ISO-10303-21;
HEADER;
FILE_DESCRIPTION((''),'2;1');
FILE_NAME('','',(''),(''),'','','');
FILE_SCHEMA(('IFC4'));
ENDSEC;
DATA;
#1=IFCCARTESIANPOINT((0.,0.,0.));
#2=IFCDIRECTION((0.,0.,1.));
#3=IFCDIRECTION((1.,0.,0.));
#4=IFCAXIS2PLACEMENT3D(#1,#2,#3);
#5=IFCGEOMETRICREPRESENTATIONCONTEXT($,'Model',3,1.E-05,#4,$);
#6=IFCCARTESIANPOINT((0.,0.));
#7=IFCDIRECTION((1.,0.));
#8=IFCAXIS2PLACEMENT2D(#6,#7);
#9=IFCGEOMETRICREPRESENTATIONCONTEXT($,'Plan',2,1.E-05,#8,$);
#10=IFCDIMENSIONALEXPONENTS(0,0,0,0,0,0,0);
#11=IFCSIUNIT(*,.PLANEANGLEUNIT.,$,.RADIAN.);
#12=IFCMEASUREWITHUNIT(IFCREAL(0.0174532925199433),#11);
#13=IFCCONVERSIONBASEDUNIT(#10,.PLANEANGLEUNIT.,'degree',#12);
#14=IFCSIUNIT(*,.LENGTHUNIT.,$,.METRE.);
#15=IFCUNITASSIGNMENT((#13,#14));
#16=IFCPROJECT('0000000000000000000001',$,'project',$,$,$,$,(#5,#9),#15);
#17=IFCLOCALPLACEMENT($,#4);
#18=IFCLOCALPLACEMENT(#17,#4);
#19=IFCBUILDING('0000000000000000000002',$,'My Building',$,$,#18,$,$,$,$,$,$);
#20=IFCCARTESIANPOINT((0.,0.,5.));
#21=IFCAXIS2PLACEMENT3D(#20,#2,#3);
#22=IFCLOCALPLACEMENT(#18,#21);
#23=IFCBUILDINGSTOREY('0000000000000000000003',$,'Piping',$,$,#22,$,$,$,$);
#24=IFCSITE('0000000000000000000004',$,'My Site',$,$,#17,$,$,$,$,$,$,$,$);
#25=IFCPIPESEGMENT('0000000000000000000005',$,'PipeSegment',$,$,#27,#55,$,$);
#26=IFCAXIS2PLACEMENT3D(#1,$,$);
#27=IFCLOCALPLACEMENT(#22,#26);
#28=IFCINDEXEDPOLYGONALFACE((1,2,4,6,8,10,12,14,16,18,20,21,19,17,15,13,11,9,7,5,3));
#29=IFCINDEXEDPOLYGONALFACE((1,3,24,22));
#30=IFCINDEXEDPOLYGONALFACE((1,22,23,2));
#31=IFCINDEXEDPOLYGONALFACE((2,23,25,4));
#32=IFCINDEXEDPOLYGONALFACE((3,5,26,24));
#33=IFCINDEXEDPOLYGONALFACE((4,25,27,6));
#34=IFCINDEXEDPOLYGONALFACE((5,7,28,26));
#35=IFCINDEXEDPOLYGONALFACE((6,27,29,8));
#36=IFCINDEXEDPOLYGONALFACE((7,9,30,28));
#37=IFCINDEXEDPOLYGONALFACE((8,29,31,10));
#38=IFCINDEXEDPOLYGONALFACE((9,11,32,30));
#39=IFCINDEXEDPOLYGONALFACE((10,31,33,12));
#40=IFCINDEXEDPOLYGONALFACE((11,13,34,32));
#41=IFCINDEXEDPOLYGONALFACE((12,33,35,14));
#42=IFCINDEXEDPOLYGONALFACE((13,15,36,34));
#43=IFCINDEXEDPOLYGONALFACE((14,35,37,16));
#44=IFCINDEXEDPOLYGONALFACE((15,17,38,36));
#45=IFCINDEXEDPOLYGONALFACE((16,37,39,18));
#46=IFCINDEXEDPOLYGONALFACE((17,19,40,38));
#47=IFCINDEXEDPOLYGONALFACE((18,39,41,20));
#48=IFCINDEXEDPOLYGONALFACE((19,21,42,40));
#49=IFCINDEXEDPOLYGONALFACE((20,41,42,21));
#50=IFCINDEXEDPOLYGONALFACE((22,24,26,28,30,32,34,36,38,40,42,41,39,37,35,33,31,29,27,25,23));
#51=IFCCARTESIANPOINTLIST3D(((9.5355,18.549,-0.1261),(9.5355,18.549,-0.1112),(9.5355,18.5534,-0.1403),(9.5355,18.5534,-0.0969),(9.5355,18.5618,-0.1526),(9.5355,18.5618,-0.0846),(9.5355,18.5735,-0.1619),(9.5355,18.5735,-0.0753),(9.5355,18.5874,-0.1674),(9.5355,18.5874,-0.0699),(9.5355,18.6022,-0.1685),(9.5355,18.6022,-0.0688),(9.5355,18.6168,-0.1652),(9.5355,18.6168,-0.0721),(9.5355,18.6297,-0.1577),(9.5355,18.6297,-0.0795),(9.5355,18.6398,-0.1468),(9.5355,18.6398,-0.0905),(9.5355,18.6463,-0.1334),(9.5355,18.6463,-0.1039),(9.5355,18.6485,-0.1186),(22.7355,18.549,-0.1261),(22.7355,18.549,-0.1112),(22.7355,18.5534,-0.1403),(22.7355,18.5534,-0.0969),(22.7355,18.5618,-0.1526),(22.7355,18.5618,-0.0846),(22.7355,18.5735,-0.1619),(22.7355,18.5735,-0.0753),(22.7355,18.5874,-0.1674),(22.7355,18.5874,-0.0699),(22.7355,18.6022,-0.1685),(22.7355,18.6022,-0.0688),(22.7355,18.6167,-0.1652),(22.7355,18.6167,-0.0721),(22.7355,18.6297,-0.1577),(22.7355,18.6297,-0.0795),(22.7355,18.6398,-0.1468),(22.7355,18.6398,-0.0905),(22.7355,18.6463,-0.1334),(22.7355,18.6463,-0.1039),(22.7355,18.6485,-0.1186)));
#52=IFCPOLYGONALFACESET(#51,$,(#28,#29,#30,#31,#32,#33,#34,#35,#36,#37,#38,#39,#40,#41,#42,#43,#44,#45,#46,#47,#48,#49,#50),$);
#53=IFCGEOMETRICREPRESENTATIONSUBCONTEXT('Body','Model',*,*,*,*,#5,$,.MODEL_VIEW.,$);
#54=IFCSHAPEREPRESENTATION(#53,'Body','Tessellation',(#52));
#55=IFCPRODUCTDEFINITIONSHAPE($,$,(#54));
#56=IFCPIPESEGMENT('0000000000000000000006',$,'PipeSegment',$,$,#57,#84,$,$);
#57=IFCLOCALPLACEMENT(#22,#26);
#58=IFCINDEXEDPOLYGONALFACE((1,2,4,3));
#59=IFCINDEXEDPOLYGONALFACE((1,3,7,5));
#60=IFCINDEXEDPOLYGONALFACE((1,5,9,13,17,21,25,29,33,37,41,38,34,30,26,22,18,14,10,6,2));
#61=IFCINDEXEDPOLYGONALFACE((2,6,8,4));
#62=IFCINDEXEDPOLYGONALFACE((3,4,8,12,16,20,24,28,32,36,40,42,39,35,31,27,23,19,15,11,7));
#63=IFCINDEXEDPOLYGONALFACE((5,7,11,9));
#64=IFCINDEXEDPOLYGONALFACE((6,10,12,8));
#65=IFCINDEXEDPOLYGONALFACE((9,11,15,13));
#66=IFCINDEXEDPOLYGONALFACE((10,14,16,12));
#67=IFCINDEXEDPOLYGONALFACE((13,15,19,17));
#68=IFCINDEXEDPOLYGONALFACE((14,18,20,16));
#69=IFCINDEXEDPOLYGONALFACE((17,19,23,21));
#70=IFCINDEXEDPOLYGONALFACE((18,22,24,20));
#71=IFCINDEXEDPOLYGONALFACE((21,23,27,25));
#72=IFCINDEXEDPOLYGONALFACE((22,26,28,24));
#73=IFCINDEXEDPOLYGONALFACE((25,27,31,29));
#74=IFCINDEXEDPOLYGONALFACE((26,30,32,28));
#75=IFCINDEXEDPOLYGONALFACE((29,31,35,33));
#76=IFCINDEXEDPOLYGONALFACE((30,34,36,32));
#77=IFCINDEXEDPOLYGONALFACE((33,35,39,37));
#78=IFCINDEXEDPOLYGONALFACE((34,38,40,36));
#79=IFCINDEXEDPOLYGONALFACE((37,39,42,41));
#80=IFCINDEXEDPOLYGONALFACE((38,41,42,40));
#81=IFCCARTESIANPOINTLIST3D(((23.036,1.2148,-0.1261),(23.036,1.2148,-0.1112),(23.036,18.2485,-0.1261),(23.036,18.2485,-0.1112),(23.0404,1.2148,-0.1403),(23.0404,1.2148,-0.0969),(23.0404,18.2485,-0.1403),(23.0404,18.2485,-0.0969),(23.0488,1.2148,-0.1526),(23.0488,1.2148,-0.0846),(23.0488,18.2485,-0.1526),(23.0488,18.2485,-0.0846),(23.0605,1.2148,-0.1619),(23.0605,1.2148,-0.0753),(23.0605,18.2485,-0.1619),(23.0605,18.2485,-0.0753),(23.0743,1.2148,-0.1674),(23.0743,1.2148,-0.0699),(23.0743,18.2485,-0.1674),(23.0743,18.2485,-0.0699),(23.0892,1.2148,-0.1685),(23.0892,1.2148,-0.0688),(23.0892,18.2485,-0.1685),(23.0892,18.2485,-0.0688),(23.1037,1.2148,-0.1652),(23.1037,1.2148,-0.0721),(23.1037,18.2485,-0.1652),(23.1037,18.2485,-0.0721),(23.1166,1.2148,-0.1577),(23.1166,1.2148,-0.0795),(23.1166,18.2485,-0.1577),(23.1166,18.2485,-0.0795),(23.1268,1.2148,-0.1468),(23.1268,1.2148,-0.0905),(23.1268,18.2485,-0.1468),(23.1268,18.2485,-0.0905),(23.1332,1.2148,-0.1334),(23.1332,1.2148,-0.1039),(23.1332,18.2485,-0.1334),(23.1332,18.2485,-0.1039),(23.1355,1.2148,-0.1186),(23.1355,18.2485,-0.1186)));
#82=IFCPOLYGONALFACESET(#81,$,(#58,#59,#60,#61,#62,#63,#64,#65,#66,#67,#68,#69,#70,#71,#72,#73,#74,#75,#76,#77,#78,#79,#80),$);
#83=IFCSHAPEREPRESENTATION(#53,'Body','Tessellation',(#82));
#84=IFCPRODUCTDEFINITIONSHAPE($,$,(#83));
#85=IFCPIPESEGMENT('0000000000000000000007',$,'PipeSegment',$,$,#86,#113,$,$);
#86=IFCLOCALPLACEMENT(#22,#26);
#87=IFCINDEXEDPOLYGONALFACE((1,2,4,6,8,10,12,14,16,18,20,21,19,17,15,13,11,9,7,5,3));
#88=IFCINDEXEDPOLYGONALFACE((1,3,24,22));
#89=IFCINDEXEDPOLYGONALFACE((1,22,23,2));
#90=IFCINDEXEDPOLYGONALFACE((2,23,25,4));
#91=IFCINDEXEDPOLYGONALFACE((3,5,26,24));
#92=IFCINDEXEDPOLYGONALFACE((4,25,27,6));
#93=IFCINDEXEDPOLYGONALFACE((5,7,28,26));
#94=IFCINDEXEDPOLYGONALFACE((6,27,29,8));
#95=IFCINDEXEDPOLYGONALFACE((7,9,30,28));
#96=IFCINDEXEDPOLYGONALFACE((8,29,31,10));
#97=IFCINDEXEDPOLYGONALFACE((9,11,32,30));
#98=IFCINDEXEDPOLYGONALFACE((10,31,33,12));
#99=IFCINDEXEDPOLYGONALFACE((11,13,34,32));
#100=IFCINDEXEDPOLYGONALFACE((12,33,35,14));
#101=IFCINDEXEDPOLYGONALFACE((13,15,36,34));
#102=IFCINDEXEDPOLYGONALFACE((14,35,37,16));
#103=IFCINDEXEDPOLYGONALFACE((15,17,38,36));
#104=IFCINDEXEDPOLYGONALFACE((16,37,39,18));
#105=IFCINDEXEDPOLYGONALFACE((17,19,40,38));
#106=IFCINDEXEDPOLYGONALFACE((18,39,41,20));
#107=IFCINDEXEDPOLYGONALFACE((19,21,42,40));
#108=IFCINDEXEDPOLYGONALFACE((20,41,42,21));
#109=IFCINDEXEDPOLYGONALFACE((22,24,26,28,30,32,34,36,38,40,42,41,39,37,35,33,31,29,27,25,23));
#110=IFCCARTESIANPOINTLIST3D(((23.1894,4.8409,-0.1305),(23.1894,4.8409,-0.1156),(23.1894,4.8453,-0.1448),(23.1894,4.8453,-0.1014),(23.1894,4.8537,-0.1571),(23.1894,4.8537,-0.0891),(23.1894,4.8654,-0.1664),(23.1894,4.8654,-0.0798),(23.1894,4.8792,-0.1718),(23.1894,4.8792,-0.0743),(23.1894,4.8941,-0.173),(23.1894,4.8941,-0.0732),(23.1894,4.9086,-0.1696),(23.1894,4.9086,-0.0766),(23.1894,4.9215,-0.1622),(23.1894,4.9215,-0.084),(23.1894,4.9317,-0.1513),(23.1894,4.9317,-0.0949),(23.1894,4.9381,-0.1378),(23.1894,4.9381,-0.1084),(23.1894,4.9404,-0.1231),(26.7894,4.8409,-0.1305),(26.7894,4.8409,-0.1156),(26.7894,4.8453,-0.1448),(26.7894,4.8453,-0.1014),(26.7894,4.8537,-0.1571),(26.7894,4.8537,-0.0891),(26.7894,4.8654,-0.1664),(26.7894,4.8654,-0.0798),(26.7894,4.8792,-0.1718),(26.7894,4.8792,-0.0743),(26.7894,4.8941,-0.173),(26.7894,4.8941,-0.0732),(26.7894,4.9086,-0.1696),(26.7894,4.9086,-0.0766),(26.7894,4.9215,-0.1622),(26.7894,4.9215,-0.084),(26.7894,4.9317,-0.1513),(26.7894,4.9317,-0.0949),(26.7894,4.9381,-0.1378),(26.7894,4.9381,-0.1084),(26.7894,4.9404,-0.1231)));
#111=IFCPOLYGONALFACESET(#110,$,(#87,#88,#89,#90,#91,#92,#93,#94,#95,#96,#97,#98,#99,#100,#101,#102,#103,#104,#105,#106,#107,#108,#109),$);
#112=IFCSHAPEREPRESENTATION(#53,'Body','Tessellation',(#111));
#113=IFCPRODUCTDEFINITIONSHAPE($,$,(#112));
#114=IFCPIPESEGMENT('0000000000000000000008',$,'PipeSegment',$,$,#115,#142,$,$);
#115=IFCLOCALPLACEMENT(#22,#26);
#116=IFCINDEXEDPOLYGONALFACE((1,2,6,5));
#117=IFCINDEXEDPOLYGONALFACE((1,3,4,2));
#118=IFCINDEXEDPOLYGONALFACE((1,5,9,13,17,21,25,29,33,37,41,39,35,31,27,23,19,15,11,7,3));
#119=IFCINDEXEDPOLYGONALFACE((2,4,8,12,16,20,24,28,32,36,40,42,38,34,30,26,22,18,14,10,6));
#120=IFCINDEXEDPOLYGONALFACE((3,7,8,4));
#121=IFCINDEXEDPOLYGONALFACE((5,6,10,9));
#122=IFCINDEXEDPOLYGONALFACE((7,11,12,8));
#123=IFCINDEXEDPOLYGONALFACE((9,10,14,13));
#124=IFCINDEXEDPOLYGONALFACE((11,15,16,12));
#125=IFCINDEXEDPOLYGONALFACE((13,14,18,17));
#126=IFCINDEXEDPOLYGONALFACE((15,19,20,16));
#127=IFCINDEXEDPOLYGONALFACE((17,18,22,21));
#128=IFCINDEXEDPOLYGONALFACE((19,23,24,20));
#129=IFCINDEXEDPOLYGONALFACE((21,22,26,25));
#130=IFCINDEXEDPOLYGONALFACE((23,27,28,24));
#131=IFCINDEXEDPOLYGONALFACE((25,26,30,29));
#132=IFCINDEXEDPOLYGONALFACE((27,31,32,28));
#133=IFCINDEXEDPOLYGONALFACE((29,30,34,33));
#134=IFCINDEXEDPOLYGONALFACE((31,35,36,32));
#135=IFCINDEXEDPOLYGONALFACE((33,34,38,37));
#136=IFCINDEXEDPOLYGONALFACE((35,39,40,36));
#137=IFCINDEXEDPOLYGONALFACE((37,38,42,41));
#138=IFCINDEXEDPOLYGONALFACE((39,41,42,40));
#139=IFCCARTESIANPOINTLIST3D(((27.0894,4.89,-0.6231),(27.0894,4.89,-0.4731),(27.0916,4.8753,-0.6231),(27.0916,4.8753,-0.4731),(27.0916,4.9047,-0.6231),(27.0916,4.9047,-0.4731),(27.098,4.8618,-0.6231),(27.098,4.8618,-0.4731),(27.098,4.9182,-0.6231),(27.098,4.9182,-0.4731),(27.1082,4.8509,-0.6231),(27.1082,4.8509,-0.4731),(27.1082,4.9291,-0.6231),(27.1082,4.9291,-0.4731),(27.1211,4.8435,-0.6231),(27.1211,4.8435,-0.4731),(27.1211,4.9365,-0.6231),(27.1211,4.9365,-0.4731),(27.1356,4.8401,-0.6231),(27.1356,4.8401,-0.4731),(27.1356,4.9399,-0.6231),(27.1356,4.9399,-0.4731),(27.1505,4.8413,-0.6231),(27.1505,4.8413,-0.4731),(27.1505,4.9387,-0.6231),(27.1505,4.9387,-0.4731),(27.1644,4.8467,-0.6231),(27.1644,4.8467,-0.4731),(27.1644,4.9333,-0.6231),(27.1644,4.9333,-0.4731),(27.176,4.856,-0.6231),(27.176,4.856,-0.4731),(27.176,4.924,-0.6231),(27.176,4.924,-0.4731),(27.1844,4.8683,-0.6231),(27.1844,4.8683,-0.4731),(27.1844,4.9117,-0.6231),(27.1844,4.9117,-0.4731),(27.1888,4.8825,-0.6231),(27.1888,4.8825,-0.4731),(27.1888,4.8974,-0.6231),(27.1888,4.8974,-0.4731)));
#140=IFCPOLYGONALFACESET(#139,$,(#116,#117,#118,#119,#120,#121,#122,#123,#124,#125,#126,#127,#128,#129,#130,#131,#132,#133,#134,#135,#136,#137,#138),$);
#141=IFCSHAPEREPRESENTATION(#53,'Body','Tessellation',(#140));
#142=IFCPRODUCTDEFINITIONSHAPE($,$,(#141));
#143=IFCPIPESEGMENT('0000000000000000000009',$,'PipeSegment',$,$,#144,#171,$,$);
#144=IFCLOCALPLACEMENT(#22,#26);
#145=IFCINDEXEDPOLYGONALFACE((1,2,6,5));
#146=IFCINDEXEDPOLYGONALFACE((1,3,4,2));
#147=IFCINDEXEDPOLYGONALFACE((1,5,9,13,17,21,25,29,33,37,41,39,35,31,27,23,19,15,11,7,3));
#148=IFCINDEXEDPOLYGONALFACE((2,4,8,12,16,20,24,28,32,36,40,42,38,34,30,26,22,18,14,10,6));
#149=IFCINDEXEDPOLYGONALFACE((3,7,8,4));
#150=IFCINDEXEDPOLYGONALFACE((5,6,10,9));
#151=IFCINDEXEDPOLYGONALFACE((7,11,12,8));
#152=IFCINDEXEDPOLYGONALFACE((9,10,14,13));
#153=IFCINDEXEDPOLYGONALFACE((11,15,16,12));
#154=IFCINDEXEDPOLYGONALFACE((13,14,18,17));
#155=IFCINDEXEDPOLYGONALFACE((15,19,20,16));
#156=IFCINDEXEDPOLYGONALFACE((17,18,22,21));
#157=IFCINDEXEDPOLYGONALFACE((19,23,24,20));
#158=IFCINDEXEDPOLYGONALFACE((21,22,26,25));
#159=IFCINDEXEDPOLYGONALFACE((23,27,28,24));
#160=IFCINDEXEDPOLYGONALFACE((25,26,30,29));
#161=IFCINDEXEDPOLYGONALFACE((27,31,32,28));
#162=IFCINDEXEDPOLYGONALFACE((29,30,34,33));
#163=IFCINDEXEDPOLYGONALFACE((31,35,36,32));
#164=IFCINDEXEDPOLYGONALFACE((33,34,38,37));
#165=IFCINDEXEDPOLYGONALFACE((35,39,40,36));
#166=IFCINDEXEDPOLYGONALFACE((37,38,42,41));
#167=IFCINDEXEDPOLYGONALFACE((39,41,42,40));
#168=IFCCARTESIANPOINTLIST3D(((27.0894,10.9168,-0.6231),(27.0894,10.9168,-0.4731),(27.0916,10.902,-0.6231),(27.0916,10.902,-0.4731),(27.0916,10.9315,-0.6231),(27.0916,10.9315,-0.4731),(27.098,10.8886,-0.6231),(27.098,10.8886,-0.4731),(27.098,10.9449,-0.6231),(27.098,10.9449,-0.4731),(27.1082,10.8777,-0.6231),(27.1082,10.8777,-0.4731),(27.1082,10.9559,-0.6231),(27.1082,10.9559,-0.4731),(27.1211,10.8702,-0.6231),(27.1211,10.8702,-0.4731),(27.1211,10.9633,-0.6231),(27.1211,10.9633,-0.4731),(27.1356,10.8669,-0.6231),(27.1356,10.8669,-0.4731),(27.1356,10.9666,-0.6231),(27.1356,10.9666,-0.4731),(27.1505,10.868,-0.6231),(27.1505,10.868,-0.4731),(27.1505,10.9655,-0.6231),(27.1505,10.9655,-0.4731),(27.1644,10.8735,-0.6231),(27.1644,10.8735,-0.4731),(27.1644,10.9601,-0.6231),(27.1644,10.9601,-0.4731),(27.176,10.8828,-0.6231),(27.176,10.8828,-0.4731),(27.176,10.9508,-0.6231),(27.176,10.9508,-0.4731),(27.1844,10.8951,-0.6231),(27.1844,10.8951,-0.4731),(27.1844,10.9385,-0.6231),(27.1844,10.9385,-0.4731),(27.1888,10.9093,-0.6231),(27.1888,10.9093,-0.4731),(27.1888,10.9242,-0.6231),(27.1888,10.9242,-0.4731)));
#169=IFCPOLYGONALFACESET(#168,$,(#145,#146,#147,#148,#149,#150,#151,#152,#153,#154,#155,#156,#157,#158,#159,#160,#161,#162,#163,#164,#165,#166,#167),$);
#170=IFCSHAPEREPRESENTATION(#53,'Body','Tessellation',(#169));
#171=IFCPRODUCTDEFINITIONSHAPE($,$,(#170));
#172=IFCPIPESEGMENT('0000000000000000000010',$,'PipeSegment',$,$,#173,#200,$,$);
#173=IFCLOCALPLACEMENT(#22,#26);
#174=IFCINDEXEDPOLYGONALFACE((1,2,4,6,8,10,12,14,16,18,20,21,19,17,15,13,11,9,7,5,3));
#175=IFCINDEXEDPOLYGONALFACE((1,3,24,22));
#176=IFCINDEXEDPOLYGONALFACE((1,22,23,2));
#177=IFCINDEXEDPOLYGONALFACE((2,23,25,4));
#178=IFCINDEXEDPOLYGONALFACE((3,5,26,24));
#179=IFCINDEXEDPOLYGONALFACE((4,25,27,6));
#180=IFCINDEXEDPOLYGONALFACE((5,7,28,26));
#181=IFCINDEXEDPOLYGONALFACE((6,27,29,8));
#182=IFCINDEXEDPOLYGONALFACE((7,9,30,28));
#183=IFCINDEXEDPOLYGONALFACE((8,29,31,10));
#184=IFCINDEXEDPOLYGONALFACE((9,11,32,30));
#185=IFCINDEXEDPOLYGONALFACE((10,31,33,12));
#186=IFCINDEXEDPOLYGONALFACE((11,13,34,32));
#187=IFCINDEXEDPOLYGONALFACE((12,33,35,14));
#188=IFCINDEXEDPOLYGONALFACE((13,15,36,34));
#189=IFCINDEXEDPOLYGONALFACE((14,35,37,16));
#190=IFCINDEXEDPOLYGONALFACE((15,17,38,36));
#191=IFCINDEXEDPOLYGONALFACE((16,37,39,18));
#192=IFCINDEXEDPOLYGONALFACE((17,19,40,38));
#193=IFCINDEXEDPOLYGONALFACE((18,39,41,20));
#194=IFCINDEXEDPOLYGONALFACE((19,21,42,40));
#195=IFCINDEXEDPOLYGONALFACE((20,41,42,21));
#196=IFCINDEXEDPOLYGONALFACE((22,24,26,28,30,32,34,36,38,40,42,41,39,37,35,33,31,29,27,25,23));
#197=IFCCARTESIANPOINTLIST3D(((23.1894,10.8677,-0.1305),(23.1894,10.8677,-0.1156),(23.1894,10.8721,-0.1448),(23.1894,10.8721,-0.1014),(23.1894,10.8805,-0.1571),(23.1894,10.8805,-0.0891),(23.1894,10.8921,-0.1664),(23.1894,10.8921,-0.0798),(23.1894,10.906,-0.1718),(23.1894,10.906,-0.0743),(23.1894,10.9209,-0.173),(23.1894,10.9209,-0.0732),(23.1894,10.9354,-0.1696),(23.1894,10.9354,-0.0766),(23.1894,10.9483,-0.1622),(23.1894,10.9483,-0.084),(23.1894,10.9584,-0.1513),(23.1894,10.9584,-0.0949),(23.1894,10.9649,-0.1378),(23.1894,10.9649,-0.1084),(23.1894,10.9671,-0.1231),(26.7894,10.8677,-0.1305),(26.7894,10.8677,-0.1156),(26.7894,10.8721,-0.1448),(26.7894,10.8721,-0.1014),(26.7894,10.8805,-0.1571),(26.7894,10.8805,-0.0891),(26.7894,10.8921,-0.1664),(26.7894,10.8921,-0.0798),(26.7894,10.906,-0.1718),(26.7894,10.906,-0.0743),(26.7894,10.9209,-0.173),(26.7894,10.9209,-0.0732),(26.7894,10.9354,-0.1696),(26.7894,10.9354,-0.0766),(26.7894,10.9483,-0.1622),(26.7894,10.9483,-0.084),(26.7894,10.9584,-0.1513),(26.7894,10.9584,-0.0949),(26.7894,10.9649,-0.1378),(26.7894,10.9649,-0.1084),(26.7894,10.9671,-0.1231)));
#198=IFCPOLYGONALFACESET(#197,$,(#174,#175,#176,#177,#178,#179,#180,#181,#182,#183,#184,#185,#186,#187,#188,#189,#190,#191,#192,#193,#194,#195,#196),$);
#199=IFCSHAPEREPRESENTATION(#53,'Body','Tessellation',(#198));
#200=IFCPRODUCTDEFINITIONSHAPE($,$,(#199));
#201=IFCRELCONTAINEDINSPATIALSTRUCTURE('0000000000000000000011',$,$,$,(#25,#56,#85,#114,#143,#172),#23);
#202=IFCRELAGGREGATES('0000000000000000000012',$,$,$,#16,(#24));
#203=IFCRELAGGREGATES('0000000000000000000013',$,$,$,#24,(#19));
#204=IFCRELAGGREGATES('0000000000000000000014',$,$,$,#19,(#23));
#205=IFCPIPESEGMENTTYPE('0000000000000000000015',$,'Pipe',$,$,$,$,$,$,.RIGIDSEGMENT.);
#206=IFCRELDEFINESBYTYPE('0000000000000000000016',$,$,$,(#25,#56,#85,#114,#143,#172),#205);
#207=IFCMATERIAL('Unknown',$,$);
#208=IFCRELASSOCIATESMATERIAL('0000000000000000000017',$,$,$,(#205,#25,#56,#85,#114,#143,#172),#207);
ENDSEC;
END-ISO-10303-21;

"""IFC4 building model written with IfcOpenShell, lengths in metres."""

from ifc_helpers import new_model, entity, si_unit, converted_unit, frame, origin_with_axes, origin_2d_with_axis, place, context, subcontext, project, spatial, circle, extrude, material, material_profile, profile_set, profile_usage, type_object, element, save


model = new_model("IFC4")

# Units and contexts
model_context = context("Model", 3, precision=1e-05, world=origin_with_axes())
plan_context = context("Plan", 2, precision=1e-05, world=origin_2d_with_axis())
body_context = subcontext(model_context, "Body", "Model", "MODEL_VIEW")
ifc_project = project(units=[converted_unit("PLANEANGLEUNIT", "degree", entity("IfcReal", 0.0174532925199433), si_unit("PLANEANGLEUNIT", "RADIAN"), dimensions=[0, 0, 0, 0, 0, 0, 0]), si_unit("LENGTHUNIT", "METRE")], contexts=[model_context, plan_context])

# Site, building, storey
site_placement = place(None, origin_with_axes())
site = spatial("IfcSite", under=ifc_project, at=site_placement, Name="My Site")
building_placement = place(site_placement, origin_with_axes())
building = spatial("IfcBuilding", under=site, at=building_placement, Name="My Building")
storey_placement = place(building_placement, frame((0.0, 0.0, 5.0), z_axis=(0.0, 0.0, 1.0), x_axis=(1.0, 0.0, 0.0)))
storey = spatial("IfcBuildingStorey", under=building, at=storey_placement, Name="Piping")

# Pipe segments
ifc_material = material(Name="Unknown")
ifc_material_profile_1 = material_profile(ifc_material, circle(Radius=0.05))
ifc_profile_set_1 = profile_set([ifc_material_profile_1])
ifc_profile_usage_1 = profile_usage(ifc_profile_set_1, cardinal=5)
pipe_segment_type = type_object("IfcPipeSegmentType", Name="Pipe", PredefinedType="RIGIDSEGMENT", material=ifc_profile_set_1)
pipe_segment_1_placement = place(storey_placement, frame((9.5355, 18.5985, -0.1186), z_axis=(1.0, -0.000001, 0.000001), x_axis=(0.000001, 1.0, 0.0)))
element("IfcPipeSegment", 1, at=pipe_segment_1_placement, inside=storey, type_object=pipe_segment_type, material=ifc_profile_usage_1, Name="PipeSegment", context=body_context, shape_type="SweptSolid", body=[
    extrude(circle(Radius=0.05), origin_with_axes(), (0.0, 0.0, 1.0), 13.2),
])
ifc_profile_usage_2 = profile_usage(ifc_profile_set_1, cardinal=5)
pipe_segment_2_placement = place(storey_placement, frame((23.0855, 18.2485, -0.1186), z_axis=(0.0, -1.0, -0.000001), x_axis=(1.0, 0.0, 0.0)))
element("IfcPipeSegment", 2, at=pipe_segment_2_placement, inside=storey, type_object=pipe_segment_type, material=ifc_profile_usage_2, Name="PipeSegment", context=body_context, shape_type="SweptSolid", body=[
    extrude(circle(Radius=0.05), origin_with_axes(), (0.0, 0.0, 1.0), 17.0337),
])
ifc_profile_usage_3 = profile_usage(ifc_profile_set_1, cardinal=5)
pipe_segment_3_placement = place(storey_placement, frame((23.1894, 4.8904, -0.1231), z_axis=(1.0, 0.0, 0.0), x_axis=(0.0, 1.0, 0.0)))
element("IfcPipeSegment", 3, at=pipe_segment_3_placement, inside=storey, type_object=pipe_segment_type, material=ifc_profile_usage_3, Name="PipeSegment", context=body_context, shape_type="SweptSolid", body=[
    extrude(circle(Radius=0.05), origin_with_axes(), (0.0, 0.0, 1.0), 3.6),
])
ifc_profile_usage_4 = profile_usage(ifc_profile_set_1, cardinal=5)
pipe_segment_4_placement = place(storey_placement, frame((27.1394, 4.89, -0.4731), z_axis=(0.0, 0.0, -1.0), x_axis=(-1.0, 0.0, 0.0)))
element("IfcPipeSegment", 4, at=pipe_segment_4_placement, inside=storey, type_object=pipe_segment_type, material=ifc_profile_usage_4, Name="PipeSegment", context=body_context, shape_type="SweptSolid", body=[
    extrude(circle(Radius=0.05), origin_with_axes(), (0.0, 0.0, 1.0), 0.15),
])
ifc_profile_usage_5 = profile_usage(ifc_profile_set_1, cardinal=5)
pipe_segment_5_placement = place(storey_placement, frame((27.1394, 10.9168, -0.4731), z_axis=(0.0, 0.0, -1.0), x_axis=(-1.0, 0.0, 0.0)))
element("IfcPipeSegment", 5, at=pipe_segment_5_placement, inside=storey, type_object=pipe_segment_type, material=ifc_profile_usage_5, Name="PipeSegment", context=body_context, shape_type="SweptSolid", body=[
    extrude(circle(Radius=0.05), origin_with_axes(), (0.0, 0.0, 1.0), 0.15),
])
ifc_profile_usage_6 = profile_usage(ifc_profile_set_1, cardinal=5)
pipe_segment_6_placement = place(storey_placement, frame((23.1894, 10.9171, -0.1231), z_axis=(1.0, 0.0, 0.0), x_axis=(0.0, 1.0, 0.0)))
element("IfcPipeSegment", 6, at=pipe_segment_6_placement, inside=storey, type_object=pipe_segment_type, material=ifc_profile_usage_6, Name="PipeSegment", context=body_context, shape_type="SweptSolid", body=[
    extrude(circle(Radius=0.05), origin_with_axes(), (0.0, 0.0, 1.0), 3.6),
])

save(model, "model.ifc")
